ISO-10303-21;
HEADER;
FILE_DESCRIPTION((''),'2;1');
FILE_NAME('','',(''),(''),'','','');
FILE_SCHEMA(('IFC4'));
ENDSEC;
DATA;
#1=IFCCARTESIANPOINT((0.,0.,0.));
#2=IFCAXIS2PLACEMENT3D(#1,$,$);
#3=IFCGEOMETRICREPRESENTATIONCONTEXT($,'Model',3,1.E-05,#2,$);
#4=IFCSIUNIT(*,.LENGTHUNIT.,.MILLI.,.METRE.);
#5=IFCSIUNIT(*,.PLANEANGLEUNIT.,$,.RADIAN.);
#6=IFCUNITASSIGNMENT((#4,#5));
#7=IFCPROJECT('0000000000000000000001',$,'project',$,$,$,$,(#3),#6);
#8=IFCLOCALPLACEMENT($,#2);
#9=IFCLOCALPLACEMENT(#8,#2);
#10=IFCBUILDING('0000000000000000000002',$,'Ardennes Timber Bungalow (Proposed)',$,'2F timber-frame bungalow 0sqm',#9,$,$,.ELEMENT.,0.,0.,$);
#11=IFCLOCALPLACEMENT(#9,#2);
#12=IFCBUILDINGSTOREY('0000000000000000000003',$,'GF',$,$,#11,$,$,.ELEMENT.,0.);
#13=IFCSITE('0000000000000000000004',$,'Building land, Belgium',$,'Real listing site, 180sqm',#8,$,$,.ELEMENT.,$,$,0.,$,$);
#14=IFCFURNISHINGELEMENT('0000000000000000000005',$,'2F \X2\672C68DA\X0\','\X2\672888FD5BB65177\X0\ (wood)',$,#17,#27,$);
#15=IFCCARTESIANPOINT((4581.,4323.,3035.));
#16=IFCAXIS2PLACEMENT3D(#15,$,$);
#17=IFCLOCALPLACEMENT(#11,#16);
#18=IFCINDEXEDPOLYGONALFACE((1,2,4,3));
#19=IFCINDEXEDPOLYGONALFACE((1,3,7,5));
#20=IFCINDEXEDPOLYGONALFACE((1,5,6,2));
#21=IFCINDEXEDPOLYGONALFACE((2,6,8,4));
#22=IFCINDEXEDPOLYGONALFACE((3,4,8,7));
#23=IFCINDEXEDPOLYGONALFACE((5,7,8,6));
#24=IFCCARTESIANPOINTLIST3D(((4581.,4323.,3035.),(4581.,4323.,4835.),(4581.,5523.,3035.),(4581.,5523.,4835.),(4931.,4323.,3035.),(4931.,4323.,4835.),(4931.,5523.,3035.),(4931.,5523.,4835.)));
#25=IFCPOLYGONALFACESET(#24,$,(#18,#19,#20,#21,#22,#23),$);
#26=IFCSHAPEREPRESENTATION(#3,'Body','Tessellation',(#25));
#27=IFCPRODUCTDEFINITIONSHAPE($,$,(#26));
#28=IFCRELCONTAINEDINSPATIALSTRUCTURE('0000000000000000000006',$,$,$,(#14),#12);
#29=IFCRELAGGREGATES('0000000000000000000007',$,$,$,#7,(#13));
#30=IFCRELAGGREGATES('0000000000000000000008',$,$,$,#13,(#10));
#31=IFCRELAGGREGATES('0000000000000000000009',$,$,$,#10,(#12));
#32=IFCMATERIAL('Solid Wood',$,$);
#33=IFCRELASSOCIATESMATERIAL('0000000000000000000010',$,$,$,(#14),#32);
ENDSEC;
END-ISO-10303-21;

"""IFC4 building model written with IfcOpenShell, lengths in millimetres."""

from ifc_helpers import new_model, si_unit, frame, frame_2d, origin, place, context, project, spatial, rectangle, extrude, material, element, save


model = new_model("IFC4")

# Units and contexts
model_context = context("Model", 3, precision=1e-05, world=origin())
ifc_project = project(units=[si_unit("LENGTHUNIT", "METRE", prefix="MILLI"), si_unit("PLANEANGLEUNIT", "RADIAN")], contexts=[model_context])

# Site, building, storey
site_placement = place(None, origin())
site = spatial("IfcSite", under=ifc_project, at=site_placement, Name="Building land, Belgium", ObjectType="Real listing site, 180sqm", CompositionType="ELEMENT", RefElevation=0.0)
building_placement = place(site_placement, origin())
building = spatial("IfcBuilding", under=site, at=building_placement, Name="Ardennes Timber Bungalow (Proposed)", ObjectType="2F timber-frame bungalow 0sqm", CompositionType="ELEMENT", ElevationOfRefHeight=0.0, ElevationOfTerrain=0.0)
storey_placement = place(building_placement, origin())
storey = spatial("IfcBuildingStorey", under=building, at=storey_placement, Name="GF", CompositionType="ELEMENT", Elevation=0.0)

# Shared definitions
ifc_material_1 = material(Name="Solid Wood")

# Furnishing element
furnishing_1_placement = place(storey_placement, frame((4581.0, 4323.0, 3035.0)))
element("IfcFurnishingElement", 1, at=furnishing_1_placement, inside=storey, material=ifc_material_1, Name="2F 本棚", Description="木製家具 (wood)", context=model_context, shape_type="SweptSolid", body=[
    extrude(rectangle(XDim=350.0, YDim=1200.0, at=frame_2d((175.0, 600.0))), frame((4581.0, 4323.0, 3035.0)), (0.0, 0.0, 1.0), 1800.0),
])

save(model, "model.ifc")
